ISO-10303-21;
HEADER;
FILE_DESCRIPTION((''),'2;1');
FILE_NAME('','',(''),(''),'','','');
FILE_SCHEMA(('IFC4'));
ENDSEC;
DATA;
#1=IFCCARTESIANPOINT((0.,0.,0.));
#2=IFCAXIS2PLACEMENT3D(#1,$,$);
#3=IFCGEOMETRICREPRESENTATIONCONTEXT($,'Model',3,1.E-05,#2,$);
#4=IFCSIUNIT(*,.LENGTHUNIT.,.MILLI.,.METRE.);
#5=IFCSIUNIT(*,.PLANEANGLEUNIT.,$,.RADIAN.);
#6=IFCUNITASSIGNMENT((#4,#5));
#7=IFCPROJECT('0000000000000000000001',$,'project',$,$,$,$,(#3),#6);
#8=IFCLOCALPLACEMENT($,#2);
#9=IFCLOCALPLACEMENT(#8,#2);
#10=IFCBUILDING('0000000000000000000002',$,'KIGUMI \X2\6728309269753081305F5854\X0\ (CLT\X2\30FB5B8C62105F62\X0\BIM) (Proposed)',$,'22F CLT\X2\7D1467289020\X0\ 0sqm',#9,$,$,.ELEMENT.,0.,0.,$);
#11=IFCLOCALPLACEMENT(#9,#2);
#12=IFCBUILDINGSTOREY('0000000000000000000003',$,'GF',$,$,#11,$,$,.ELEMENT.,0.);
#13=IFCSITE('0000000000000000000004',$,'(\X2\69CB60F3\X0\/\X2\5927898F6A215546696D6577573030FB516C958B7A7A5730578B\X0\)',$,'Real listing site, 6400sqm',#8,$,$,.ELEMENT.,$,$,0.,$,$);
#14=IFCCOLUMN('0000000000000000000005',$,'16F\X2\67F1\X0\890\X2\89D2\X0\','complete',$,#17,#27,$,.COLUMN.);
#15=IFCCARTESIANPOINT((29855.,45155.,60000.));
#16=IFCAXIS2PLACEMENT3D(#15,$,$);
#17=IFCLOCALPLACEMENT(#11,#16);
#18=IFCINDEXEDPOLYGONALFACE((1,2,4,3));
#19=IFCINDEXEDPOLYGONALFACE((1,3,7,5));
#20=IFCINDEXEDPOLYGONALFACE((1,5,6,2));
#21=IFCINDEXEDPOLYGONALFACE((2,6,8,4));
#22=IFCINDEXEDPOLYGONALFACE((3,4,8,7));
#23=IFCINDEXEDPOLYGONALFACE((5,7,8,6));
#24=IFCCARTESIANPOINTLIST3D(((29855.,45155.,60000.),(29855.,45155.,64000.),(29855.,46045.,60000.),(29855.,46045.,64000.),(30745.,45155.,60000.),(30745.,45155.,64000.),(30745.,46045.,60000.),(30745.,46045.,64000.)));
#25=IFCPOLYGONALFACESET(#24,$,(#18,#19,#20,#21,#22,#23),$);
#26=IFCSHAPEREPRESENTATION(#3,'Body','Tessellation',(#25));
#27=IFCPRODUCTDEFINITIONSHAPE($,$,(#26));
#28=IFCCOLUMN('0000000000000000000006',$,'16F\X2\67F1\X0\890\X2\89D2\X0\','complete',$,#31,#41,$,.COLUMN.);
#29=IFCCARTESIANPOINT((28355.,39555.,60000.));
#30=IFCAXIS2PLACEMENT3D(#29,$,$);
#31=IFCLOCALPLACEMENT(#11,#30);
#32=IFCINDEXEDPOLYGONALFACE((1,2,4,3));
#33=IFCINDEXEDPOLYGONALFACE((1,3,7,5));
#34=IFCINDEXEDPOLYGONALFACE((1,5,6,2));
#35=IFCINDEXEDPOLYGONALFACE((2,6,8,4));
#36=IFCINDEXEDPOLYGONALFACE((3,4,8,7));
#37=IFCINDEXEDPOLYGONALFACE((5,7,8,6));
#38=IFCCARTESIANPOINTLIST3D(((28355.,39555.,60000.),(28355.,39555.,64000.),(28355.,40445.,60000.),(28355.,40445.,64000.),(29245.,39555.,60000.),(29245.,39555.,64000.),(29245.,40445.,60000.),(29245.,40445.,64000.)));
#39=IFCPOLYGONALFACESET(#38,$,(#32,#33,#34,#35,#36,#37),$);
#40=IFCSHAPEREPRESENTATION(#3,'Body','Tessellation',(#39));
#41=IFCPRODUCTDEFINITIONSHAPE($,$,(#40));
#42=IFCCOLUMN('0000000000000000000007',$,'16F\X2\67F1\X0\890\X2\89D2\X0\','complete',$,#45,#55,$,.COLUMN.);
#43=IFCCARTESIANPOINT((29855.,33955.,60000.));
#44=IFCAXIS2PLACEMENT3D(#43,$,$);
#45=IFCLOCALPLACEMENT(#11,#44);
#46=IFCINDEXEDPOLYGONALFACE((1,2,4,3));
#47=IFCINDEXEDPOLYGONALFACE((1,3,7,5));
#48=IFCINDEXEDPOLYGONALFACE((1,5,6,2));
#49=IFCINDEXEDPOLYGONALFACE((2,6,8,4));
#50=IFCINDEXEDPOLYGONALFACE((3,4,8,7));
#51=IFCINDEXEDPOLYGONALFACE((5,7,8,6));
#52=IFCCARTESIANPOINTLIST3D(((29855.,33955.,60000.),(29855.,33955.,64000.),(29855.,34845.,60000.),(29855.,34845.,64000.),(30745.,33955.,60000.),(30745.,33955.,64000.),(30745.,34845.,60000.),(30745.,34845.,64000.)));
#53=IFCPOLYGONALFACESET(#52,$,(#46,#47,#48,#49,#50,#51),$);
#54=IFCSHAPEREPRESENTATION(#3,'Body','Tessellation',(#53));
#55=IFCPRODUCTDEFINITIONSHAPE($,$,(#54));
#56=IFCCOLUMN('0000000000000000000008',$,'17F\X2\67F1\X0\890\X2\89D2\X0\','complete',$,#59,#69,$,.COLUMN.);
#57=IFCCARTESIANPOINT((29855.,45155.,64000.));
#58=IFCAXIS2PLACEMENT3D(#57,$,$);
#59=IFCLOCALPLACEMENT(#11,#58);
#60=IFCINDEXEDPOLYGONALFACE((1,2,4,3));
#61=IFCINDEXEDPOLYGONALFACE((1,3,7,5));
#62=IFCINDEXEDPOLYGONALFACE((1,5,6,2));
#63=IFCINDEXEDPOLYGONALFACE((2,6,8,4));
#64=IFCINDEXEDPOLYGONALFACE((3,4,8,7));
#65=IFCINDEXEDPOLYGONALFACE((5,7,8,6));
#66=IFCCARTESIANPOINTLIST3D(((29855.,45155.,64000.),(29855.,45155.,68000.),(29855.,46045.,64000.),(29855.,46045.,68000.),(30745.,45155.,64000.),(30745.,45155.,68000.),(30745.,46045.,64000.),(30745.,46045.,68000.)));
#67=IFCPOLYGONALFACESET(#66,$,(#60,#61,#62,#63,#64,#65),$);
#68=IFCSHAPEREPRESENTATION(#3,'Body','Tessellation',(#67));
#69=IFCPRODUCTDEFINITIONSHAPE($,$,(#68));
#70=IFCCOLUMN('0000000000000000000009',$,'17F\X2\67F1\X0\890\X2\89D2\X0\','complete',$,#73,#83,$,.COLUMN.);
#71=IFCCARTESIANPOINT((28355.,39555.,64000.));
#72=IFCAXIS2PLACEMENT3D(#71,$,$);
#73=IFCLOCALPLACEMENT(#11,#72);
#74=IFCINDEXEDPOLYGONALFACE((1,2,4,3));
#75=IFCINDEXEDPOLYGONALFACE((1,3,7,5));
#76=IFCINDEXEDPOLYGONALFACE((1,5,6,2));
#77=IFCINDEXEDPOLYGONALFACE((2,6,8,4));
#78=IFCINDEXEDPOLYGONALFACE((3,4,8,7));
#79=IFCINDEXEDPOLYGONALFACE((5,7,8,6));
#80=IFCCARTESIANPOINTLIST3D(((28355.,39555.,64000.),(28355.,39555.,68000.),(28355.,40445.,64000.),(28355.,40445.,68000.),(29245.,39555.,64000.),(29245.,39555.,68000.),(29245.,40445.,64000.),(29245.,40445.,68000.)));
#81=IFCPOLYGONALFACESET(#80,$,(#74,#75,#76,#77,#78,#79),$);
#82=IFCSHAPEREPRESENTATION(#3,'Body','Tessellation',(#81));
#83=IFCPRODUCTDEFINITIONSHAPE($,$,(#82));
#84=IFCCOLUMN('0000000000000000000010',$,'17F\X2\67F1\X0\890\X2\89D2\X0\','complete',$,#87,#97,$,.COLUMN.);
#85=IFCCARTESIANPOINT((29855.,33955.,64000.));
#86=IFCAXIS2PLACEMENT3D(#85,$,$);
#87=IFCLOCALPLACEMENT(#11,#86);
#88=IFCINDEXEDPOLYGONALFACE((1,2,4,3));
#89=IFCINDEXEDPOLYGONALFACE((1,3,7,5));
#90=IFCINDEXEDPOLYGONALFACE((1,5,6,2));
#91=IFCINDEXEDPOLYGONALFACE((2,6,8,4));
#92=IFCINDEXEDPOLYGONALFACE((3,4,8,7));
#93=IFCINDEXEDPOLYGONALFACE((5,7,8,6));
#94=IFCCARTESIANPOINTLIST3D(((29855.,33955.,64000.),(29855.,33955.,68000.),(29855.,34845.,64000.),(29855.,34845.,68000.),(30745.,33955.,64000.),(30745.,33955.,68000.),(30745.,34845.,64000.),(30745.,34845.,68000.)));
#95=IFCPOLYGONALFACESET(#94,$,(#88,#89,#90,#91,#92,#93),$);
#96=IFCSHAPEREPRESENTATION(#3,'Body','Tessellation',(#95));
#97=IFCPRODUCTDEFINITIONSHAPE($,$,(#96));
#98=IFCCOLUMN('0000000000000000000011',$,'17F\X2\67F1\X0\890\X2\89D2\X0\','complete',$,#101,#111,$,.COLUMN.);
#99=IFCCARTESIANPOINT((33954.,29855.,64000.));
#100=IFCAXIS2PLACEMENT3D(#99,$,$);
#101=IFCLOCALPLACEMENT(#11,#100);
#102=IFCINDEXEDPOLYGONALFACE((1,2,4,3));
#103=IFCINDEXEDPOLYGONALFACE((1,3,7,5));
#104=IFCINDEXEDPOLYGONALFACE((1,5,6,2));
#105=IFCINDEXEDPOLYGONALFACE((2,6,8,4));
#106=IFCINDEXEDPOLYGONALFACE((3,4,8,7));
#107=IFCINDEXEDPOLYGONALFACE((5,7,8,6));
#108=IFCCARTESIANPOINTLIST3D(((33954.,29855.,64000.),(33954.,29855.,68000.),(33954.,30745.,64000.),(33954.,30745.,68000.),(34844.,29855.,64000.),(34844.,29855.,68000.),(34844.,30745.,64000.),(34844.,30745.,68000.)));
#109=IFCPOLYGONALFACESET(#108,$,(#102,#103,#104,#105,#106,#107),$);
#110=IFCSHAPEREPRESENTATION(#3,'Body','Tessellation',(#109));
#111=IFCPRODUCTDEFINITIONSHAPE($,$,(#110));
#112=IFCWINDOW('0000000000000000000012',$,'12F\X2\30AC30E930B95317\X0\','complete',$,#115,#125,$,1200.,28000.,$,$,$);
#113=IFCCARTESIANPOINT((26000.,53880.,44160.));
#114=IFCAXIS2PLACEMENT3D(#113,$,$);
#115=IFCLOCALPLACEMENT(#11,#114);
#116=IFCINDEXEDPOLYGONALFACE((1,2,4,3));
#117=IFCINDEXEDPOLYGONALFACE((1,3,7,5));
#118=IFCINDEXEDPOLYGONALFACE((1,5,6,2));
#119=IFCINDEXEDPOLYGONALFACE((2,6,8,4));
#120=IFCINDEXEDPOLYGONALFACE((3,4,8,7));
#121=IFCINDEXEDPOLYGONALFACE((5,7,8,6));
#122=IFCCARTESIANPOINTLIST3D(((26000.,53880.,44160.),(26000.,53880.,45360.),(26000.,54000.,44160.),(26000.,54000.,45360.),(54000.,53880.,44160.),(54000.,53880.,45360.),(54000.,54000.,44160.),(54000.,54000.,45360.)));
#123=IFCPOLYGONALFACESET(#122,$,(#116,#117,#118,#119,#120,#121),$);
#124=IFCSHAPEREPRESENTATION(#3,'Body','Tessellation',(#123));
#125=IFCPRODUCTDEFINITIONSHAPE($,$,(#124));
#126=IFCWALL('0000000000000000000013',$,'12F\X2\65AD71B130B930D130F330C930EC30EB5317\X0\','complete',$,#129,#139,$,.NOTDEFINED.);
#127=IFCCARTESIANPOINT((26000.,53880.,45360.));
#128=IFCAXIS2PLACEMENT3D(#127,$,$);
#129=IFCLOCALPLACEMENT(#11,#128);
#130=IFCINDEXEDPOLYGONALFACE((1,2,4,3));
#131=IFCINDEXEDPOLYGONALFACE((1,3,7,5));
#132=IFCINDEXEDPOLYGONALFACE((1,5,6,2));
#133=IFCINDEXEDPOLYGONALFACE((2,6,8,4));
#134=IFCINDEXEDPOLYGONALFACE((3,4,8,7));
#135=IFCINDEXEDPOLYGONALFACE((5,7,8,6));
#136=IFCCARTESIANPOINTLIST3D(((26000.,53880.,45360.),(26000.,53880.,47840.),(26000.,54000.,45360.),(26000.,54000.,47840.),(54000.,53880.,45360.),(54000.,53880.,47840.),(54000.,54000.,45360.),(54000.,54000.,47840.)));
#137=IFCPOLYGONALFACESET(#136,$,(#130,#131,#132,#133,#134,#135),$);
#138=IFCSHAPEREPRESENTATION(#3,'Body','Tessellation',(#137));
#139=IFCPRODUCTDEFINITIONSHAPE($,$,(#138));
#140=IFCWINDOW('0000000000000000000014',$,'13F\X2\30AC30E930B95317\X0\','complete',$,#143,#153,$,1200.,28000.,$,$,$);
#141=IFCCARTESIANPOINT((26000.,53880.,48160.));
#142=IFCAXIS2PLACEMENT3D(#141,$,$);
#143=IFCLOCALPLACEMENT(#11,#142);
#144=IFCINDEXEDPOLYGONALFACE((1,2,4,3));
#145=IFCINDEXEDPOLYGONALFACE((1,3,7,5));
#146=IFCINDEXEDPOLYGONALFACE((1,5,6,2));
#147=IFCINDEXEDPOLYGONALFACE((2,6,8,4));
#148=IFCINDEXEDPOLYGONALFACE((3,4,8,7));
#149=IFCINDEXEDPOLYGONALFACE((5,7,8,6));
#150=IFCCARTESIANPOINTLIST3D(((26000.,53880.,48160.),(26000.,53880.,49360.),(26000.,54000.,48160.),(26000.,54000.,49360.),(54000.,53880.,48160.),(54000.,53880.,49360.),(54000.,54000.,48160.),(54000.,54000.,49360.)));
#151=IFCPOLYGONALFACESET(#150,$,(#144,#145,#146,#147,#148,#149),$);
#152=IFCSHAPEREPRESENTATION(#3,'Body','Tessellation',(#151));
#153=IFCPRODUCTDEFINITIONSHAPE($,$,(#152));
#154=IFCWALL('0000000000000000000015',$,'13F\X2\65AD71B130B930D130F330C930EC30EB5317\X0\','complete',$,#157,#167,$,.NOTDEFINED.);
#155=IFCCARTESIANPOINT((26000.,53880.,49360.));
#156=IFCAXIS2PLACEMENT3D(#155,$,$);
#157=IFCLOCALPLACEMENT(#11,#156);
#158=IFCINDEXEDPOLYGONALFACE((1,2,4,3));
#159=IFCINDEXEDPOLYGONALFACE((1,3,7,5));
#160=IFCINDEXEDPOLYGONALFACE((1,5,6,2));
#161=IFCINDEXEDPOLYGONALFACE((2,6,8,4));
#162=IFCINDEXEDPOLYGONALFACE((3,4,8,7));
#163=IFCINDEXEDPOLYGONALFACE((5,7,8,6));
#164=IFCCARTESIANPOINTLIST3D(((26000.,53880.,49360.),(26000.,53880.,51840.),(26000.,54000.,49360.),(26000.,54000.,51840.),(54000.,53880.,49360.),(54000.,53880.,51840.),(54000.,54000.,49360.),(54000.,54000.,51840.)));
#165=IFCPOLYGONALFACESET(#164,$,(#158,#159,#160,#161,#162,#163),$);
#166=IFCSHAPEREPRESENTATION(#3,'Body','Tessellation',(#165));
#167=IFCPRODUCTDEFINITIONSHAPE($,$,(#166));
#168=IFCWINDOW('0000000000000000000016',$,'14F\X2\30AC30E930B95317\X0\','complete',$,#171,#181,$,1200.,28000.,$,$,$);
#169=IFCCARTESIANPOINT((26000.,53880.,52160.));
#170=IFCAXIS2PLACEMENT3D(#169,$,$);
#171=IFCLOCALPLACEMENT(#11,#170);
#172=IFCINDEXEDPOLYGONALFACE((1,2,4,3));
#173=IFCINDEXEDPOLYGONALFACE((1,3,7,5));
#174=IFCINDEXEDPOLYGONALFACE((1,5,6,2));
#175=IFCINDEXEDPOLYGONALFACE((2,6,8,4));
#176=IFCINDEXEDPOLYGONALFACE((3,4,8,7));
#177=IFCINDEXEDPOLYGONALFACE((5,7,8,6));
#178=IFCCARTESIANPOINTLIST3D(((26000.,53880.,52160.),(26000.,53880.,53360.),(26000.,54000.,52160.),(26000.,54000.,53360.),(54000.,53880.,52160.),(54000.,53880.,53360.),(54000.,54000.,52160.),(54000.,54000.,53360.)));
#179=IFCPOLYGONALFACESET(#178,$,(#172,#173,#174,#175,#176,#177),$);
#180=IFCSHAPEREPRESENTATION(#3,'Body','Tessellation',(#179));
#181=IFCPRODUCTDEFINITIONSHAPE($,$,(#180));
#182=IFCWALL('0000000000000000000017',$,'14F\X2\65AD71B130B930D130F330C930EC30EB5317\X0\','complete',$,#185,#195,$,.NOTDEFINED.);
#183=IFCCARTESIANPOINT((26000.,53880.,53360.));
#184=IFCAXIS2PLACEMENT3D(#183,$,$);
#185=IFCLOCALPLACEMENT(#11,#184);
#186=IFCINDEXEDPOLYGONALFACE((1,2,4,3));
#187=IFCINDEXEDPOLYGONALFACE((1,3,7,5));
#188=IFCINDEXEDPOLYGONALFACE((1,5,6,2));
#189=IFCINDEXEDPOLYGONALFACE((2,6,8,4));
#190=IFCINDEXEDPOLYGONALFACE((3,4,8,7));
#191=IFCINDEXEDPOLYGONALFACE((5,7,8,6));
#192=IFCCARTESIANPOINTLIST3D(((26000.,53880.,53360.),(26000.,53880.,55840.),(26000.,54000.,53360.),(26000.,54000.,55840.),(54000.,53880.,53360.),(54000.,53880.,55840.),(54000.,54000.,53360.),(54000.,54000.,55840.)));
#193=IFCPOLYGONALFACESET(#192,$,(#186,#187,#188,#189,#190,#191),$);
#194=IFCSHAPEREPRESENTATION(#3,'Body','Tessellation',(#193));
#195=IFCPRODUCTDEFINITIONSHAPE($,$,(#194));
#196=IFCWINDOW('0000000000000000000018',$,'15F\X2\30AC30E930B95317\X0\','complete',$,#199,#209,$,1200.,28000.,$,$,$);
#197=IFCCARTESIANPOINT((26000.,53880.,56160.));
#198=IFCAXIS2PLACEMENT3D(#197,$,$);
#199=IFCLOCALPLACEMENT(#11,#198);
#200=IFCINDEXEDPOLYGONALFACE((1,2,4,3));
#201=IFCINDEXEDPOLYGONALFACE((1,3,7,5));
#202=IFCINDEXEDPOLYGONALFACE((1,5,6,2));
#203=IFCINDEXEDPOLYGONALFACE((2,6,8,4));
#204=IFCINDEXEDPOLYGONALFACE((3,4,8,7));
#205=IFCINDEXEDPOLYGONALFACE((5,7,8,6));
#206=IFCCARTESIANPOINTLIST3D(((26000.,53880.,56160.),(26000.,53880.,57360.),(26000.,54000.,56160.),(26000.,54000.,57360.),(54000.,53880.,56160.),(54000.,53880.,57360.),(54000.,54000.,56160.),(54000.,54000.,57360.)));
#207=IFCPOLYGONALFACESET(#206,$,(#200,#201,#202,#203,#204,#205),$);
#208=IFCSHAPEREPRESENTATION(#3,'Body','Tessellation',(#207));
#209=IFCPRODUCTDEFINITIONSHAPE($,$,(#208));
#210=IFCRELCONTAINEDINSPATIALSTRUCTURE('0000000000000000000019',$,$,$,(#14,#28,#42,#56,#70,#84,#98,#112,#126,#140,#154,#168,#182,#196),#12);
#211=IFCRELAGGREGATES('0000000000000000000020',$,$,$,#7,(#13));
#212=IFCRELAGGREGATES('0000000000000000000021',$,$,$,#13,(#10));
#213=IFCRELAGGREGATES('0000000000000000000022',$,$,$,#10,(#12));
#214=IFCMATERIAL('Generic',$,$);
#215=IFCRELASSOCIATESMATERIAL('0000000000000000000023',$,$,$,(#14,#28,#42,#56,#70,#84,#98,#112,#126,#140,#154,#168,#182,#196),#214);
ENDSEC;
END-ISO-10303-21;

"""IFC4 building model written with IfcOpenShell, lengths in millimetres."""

from ifc_helpers import new_model, si_unit, frame, frame_2d, origin, place, context, project, spatial, rectangle, extrude, material, element, save


model = new_model("IFC4")

# Units and contexts
model_context = context("Model", 3, precision=1e-05, world=origin())
ifc_project = project(units=[si_unit("LENGTHUNIT", "METRE", prefix="MILLI"), si_unit("PLANEANGLEUNIT", "RADIAN")], contexts=[model_context])

# Site, building, storey
site_placement = place(None, origin())
site = spatial("IfcSite", under=ifc_project, at=site_placement, Name="(構想/大規模商業敷地・公開空地型)", ObjectType="Real listing site, 6400sqm", CompositionType="ELEMENT", RefElevation=0.0)
building_placement = place(site_placement, origin())
building = spatial("IfcBuilding", under=site, at=building_placement, Name="KIGUMI 木を極めた塔 (CLT・完成形BIM) (Proposed)", ObjectType="22F CLT純木造 0sqm", CompositionType="ELEMENT", ElevationOfRefHeight=0.0, ElevationOfTerrain=0.0)
storey_placement = place(building_placement, origin())
storey = spatial("IfcBuildingStorey", under=building, at=storey_placement, Name="GF", CompositionType="ELEMENT", Elevation=0.0)

# Columns
ifc_material = material(Name="Generic")
column_1_placement = place(storey_placement, frame((29855.0, 45155.0, 60000.0)))
element("IfcColumn", 1, at=column_1_placement, inside=storey, material=ifc_material, Name="16F柱890角", Description="complete", PredefinedType="COLUMN", context=model_context, shape_type="SweptSolid", body=[
    extrude(rectangle(XDim=890.0, YDim=890.0, at=frame_2d((445.0, 445.0))), frame((29855.0, 45155.0, 60000.0)), (0.0, 0.0, 1.0), 4000.0),
])
column_2_placement = place(storey_placement, frame((28355.0, 39555.0, 60000.0)))
element("IfcColumn", 2, at=column_2_placement, inside=storey, material=ifc_material, Name="16F柱890角", Description="complete", PredefinedType="COLUMN", context=model_context, shape_type="SweptSolid", body=[
    extrude(rectangle(XDim=890.0, YDim=890.0, at=frame_2d((445.0, 445.0))), frame((28355.0, 39555.0, 60000.0)), (0.0, 0.0, 1.0), 4000.0),
])
column_3_placement = place(storey_placement, frame((29855.0, 33955.0, 60000.0)))
element("IfcColumn", 3, at=column_3_placement, inside=storey, material=ifc_material, Name="16F柱890角", Description="complete", PredefinedType="COLUMN", context=model_context, shape_type="SweptSolid", body=[
    extrude(rectangle(XDim=890.0, YDim=890.0, at=frame_2d((445.0, 445.0))), frame((29855.0, 33955.0, 60000.0)), (0.0, 0.0, 1.0), 4000.0),
])
column_4_placement = place(storey_placement, frame((29855.0, 45155.0, 64000.0)))
element("IfcColumn", 4, at=column_4_placement, inside=storey, material=ifc_material, Name="17F柱890角", Description="complete", PredefinedType="COLUMN", context=model_context, shape_type="SweptSolid", body=[
    extrude(rectangle(XDim=890.0, YDim=890.0, at=frame_2d((445.0, 445.0))), frame((29855.0, 45155.0, 64000.0)), (0.0, 0.0, 1.0), 4000.0),
])
column_5_placement = place(storey_placement, frame((28355.0, 39555.0, 64000.0)))
element("IfcColumn", 5, at=column_5_placement, inside=storey, material=ifc_material, Name="17F柱890角", Description="complete", PredefinedType="COLUMN", context=model_context, shape_type="SweptSolid", body=[
    extrude(rectangle(XDim=890.0, YDim=890.0, at=frame_2d((445.0, 445.0))), frame((28355.0, 39555.0, 64000.0)), (0.0, 0.0, 1.0), 4000.0),
])
column_6_placement = place(storey_placement, frame((29855.0, 33955.0, 64000.0)))
element("IfcColumn", 6, at=column_6_placement, inside=storey, material=ifc_material, Name="17F柱890角", Description="complete", PredefinedType="COLUMN", context=model_context, shape_type="SweptSolid", body=[
    extrude(rectangle(XDim=890.0, YDim=890.0, at=frame_2d((445.0, 445.0))), frame((29855.0, 33955.0, 64000.0)), (0.0, 0.0, 1.0), 4000.0),
])
column_7_placement = place(storey_placement, frame((33954.0, 29855.0, 64000.0)))
element("IfcColumn", 7, at=column_7_placement, inside=storey, material=ifc_material, Name="17F柱890角", Description="complete", PredefinedType="COLUMN", context=model_context, shape_type="SweptSolid", body=[
    extrude(rectangle(XDim=890.0, YDim=890.0, at=frame_2d((445.0, 445.0))), frame((33954.0, 29855.0, 64000.0)), (0.0, 0.0, 1.0), 4000.0),
])

# Window
window_1_placement = place(storey_placement, frame((26000.0, 53880.0, 44160.0)))
element("IfcWindow", 8, at=window_1_placement, inside=storey, material=ifc_material, Name="12Fガラス北", Description="complete", OverallHeight=1200.0, OverallWidth=28000.0, context=model_context, shape_type="SweptSolid", body=[
    extrude(rectangle(XDim=28000.0, YDim=120.0, at=frame_2d((14000.0, 60.0))), frame((26000.0, 53880.0, 44160.0)), (0.0, 0.0, 1.0), 1200.0),
])

# Wall
wall_1_placement = place(storey_placement, frame((26000.0, 53880.0, 45360.0)))
element("IfcWall", 9, at=wall_1_placement, inside=storey, material=ifc_material, Name="12F断熱スパンドレル北", Description="complete", PredefinedType="NOTDEFINED", context=model_context, shape_type="SweptSolid", body=[
    extrude(rectangle(XDim=28000.0, YDim=120.0, at=frame_2d((14000.0, 60.0))), frame((26000.0, 53880.0, 45360.0)), (0.0, 0.0, 1.0), 2480.0),
])

# Window
window_2_placement = place(storey_placement, frame((26000.0, 53880.0, 48160.0)))
element("IfcWindow", 10, at=window_2_placement, inside=storey, material=ifc_material, Name="13Fガラス北", Description="complete", OverallHeight=1200.0, OverallWidth=28000.0, context=model_context, shape_type="SweptSolid", body=[
    extrude(rectangle(XDim=28000.0, YDim=120.0, at=frame_2d((14000.0, 60.0))), frame((26000.0, 53880.0, 48160.0)), (0.0, 0.0, 1.0), 1200.0),
])

# Wall
wall_2_placement = place(storey_placement, frame((26000.0, 53880.0, 49360.0)))
element("IfcWall", 11, at=wall_2_placement, inside=storey, material=ifc_material, Name="13F断熱スパンドレル北", Description="complete", PredefinedType="NOTDEFINED", context=model_context, shape_type="SweptSolid", body=[
    extrude(rectangle(XDim=28000.0, YDim=120.0, at=frame_2d((14000.0, 60.0))), frame((26000.0, 53880.0, 49360.0)), (0.0, 0.0, 1.0), 2480.0),
])

# Window
window_3_placement = place(storey_placement, frame((26000.0, 53880.0, 52160.0)))
element("IfcWindow", 12, at=window_3_placement, inside=storey, material=ifc_material, Name="14Fガラス北", Description="complete", OverallHeight=1200.0, OverallWidth=28000.0, context=model_context, shape_type="SweptSolid", body=[
    extrude(rectangle(XDim=28000.0, YDim=120.0, at=frame_2d((14000.0, 60.0))), frame((26000.0, 53880.0, 52160.0)), (0.0, 0.0, 1.0), 1200.0),
])

# Wall
wall_3_placement = place(storey_placement, frame((26000.0, 53880.0, 53360.0)))
element("IfcWall", 13, at=wall_3_placement, inside=storey, material=ifc_material, Name="14F断熱スパンドレル北", Description="complete", PredefinedType="NOTDEFINED", context=model_context, shape_type="SweptSolid", body=[
    extrude(rectangle(XDim=28000.0, YDim=120.0, at=frame_2d((14000.0, 60.0))), frame((26000.0, 53880.0, 53360.0)), (0.0, 0.0, 1.0), 2480.0),
])

# Window
window_4_placement = place(storey_placement, frame((26000.0, 53880.0, 56160.0)))
element("IfcWindow", 14, at=window_4_placement, inside=storey, material=ifc_material, Name="15Fガラス北", Description="complete", OverallHeight=1200.0, OverallWidth=28000.0, context=model_context, shape_type="SweptSolid", body=[
    extrude(rectangle(XDim=28000.0, YDim=120.0, at=frame_2d((14000.0, 60.0))), frame((26000.0, 53880.0, 56160.0)), (0.0, 0.0, 1.0), 1200.0),
])

save(model, "model.ifc")
